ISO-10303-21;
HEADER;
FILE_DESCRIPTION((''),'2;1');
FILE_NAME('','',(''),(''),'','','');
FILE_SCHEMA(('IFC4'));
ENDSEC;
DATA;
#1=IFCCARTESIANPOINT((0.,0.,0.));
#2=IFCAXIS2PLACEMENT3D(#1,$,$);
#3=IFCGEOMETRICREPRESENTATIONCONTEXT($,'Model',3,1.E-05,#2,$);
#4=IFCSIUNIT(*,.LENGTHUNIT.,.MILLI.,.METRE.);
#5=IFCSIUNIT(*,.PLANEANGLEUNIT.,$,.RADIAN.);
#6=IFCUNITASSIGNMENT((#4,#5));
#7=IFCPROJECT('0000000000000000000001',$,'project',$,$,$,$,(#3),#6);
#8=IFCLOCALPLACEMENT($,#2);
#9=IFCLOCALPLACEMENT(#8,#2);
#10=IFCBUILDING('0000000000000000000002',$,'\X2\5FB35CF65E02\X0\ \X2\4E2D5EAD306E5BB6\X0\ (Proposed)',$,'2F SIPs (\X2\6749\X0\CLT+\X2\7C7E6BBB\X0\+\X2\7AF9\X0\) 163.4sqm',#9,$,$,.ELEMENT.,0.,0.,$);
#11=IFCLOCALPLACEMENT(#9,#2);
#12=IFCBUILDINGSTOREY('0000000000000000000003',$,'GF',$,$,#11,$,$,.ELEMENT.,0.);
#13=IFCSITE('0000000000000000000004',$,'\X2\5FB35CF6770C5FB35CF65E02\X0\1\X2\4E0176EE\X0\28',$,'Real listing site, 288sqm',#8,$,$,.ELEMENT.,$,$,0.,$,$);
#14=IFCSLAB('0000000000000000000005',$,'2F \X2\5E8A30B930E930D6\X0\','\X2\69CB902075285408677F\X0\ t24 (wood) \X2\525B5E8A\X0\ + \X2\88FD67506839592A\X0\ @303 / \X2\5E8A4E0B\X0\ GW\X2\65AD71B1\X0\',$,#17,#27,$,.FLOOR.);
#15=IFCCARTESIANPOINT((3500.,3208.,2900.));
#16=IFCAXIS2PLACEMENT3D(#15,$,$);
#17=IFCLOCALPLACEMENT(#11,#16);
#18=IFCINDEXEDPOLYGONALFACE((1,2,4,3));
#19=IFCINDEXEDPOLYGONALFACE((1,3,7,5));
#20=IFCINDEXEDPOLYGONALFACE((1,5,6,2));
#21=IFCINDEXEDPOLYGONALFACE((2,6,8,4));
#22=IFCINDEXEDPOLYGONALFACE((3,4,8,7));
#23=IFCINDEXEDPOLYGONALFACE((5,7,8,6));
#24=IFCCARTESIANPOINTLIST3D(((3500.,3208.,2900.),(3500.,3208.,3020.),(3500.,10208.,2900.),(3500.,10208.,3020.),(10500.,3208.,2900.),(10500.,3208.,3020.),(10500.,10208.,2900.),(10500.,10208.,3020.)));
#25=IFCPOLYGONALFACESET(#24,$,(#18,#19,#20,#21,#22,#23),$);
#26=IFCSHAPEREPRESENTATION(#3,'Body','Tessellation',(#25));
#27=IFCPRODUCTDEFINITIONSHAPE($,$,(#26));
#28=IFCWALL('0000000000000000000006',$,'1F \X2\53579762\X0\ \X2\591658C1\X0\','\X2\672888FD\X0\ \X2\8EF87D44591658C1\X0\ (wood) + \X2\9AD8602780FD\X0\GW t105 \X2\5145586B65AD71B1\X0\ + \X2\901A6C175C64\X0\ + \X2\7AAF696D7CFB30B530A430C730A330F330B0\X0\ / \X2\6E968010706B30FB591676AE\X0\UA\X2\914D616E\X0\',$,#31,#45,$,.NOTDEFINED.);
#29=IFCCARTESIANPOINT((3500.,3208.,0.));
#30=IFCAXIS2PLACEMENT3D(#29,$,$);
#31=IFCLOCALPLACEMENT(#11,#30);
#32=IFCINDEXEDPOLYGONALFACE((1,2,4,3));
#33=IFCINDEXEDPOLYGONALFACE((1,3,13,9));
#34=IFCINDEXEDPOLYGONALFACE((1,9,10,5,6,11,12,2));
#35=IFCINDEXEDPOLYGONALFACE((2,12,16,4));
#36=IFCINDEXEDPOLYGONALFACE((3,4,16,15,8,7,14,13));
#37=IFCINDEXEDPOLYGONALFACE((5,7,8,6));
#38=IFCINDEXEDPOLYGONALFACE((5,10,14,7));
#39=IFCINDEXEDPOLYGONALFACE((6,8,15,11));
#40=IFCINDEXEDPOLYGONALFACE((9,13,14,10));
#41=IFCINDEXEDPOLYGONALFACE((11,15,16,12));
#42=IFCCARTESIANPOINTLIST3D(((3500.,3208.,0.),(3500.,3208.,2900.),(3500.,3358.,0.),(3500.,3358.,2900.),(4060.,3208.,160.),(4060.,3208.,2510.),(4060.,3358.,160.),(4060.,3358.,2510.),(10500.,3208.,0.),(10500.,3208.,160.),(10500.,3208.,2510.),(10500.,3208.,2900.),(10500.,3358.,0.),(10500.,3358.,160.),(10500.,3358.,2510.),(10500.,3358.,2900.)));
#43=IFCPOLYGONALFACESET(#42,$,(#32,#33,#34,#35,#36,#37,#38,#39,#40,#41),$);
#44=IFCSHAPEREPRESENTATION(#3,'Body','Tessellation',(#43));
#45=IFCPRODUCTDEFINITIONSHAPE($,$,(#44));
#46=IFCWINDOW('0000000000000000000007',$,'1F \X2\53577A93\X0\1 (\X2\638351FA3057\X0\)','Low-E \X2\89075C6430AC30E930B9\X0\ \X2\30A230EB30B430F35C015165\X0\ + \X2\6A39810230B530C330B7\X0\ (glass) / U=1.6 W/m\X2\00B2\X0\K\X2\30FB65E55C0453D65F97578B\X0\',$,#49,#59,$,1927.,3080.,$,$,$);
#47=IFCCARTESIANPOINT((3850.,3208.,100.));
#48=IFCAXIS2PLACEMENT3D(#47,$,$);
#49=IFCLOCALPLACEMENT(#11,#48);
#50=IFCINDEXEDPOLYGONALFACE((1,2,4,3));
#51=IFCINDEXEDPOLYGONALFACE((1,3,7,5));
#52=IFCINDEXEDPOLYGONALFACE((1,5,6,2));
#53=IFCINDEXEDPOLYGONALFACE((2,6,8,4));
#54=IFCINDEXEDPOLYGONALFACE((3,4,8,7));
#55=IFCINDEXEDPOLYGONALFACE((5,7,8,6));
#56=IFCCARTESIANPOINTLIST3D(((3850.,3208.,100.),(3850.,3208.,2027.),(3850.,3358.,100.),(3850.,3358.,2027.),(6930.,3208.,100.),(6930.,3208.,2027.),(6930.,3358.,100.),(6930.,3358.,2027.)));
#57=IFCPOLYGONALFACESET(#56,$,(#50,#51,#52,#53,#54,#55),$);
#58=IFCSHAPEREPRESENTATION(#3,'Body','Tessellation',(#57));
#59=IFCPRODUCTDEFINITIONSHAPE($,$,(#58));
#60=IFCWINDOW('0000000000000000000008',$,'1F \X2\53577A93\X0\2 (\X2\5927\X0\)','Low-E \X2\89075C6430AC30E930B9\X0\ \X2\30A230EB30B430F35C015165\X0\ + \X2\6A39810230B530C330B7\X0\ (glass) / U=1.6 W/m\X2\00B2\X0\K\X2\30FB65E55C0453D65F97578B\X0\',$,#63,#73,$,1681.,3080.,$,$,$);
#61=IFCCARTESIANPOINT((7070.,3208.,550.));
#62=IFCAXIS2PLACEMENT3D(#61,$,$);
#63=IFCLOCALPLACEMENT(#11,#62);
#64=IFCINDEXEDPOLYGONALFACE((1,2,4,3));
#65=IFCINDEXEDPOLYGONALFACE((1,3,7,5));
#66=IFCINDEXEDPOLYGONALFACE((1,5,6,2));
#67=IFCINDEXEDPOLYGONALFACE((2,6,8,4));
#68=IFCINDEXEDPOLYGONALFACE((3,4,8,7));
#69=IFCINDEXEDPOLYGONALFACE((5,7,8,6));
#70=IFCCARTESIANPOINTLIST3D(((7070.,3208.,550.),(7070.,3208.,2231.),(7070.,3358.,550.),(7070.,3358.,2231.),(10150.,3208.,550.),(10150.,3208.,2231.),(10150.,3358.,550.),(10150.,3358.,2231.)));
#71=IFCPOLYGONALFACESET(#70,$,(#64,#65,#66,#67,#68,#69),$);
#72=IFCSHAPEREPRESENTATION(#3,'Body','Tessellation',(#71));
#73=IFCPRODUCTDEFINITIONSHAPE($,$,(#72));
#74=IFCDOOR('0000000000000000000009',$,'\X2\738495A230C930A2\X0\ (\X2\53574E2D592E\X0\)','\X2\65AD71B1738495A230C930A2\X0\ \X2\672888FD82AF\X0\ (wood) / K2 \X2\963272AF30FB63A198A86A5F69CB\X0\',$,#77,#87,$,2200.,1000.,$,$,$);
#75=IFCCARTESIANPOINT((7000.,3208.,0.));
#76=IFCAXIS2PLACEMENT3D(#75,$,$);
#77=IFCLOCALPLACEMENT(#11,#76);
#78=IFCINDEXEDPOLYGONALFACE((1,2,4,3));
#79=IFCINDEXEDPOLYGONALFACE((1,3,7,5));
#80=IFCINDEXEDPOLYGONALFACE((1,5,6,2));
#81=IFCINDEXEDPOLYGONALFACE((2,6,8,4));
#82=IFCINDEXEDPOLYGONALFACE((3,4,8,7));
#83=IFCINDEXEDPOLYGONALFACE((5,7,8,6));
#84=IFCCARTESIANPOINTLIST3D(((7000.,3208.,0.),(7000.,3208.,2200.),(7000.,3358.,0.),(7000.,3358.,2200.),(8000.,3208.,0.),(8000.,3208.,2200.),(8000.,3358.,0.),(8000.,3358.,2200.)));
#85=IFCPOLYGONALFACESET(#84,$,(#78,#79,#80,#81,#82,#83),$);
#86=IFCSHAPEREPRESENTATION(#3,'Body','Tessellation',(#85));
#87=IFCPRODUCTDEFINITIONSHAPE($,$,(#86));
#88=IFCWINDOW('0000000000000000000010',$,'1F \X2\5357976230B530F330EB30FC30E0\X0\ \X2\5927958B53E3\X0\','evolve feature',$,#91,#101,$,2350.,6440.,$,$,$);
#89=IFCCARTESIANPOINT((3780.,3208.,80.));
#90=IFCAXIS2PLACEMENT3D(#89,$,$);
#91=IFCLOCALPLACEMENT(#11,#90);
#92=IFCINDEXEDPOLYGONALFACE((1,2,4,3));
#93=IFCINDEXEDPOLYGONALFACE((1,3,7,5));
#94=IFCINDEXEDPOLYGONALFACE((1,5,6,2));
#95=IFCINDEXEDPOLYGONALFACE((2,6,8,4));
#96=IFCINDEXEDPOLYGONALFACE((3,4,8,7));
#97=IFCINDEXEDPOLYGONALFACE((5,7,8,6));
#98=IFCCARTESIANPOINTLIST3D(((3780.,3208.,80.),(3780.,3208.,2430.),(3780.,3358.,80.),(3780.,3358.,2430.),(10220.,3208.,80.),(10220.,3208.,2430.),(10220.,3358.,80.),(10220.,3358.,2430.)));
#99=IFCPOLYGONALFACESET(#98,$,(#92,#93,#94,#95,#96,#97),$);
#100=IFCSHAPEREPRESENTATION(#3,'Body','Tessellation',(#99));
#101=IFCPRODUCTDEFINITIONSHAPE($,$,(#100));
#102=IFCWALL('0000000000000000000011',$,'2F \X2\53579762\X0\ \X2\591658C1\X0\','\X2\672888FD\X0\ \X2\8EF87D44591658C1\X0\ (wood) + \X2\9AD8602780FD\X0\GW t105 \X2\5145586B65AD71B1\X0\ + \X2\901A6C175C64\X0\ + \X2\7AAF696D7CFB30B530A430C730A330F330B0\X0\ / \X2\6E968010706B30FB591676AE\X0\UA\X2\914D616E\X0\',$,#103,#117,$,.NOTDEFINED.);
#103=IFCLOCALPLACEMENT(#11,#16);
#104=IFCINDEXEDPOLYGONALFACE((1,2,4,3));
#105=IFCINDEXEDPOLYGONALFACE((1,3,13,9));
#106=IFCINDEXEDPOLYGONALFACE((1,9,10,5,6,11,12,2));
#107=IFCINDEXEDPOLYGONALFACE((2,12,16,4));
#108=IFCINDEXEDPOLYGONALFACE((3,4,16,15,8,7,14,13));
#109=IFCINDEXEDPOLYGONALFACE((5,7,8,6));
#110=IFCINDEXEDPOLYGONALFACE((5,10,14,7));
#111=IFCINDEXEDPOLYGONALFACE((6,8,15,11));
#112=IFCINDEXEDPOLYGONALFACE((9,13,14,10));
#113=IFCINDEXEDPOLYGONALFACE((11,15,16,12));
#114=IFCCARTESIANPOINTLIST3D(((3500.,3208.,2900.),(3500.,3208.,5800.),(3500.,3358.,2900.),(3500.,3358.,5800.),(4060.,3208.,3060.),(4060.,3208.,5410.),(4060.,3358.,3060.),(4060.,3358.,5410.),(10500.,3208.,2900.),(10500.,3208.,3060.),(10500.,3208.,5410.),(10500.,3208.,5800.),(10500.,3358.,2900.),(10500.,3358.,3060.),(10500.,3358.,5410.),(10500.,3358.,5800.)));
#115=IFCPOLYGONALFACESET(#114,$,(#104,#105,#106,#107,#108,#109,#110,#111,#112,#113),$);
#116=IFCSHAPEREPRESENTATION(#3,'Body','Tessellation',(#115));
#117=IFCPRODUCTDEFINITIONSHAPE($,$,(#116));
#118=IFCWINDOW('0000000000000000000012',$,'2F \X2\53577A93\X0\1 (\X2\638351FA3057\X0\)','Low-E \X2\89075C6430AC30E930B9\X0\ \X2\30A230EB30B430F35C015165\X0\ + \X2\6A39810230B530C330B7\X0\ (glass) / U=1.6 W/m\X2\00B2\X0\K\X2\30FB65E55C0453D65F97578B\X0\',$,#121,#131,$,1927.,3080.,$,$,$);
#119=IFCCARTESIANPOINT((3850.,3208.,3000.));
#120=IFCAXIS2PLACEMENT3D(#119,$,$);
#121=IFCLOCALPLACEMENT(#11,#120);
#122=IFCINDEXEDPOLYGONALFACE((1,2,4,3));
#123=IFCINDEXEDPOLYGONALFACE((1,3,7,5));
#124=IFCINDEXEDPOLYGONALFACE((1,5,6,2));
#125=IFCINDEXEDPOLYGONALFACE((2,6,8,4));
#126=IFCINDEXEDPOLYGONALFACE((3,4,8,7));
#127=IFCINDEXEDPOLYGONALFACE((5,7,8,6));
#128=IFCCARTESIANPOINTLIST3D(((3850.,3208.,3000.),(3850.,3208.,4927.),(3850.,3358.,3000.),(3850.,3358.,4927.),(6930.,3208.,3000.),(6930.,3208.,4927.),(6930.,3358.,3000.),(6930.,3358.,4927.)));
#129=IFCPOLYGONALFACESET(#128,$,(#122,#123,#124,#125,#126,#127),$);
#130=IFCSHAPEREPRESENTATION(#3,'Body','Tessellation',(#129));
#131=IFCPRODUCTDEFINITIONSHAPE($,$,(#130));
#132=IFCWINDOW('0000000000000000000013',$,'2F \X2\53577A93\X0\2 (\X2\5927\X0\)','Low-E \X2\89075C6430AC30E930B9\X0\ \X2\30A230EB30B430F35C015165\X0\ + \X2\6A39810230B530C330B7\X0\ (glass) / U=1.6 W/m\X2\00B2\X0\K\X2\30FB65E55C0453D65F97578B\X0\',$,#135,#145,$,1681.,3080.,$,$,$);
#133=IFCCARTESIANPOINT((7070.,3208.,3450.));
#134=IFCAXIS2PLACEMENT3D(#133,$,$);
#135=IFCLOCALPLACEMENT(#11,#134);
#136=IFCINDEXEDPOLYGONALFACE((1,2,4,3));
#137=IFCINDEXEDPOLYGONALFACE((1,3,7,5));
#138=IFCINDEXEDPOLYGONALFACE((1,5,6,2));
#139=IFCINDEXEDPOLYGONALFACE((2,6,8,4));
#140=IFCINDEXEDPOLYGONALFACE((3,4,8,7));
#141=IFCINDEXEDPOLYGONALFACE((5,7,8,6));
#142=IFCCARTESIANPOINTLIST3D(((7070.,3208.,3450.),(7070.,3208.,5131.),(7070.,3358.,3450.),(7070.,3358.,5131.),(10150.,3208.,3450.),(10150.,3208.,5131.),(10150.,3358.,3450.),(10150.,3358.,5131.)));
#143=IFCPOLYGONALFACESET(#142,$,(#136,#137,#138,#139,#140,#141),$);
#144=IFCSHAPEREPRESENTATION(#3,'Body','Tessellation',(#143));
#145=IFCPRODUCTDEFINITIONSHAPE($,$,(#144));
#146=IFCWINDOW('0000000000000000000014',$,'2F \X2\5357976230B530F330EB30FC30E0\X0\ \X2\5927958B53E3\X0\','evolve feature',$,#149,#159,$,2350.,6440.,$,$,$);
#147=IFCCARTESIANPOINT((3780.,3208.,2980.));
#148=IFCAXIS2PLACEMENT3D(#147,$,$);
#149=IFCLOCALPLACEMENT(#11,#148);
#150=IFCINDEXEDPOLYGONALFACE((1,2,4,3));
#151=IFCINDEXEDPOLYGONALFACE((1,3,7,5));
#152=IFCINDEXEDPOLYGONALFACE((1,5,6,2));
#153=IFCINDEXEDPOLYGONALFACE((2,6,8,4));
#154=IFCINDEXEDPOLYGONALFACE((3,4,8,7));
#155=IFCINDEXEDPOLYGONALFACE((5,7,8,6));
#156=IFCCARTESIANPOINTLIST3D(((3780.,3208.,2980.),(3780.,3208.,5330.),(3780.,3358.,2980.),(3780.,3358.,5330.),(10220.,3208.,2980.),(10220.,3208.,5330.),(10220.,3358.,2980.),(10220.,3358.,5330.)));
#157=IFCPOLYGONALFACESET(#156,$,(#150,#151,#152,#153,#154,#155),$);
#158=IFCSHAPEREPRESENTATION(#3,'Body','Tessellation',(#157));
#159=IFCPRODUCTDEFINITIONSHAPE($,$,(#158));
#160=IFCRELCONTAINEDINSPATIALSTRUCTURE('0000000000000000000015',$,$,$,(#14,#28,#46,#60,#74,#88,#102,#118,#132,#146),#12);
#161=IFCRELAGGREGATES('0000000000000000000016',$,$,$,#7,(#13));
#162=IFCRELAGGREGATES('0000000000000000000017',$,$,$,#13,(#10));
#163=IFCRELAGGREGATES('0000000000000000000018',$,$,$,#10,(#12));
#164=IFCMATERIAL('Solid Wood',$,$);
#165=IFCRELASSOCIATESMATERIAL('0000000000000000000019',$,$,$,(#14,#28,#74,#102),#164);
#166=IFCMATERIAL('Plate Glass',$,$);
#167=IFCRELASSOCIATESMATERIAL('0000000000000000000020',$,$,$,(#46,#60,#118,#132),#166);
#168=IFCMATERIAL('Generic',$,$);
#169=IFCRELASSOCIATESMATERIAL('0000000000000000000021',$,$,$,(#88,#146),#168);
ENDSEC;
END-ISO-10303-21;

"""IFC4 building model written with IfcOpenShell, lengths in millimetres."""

from ifc_helpers import new_model, si_unit, frame, frame_2d, origin, place, context, project, spatial, rectangle, extrude, material, element, fill, save


model = new_model("IFC4")

# Units and contexts
model_context = context("Model", 3, precision=1e-05, world=origin())
ifc_project = project(units=[si_unit("LENGTHUNIT", "METRE", prefix="MILLI"), si_unit("PLANEANGLEUNIT", "RADIAN")], contexts=[model_context])

# Site, building, storey
site_placement = place(None, origin())
site = spatial("IfcSite", under=ifc_project, at=site_placement, Name="徳島県徳島市1丁目28", ObjectType="Real listing site, 288sqm", CompositionType="ELEMENT", RefElevation=0.0)
building_placement = place(site_placement, origin())
building = spatial("IfcBuilding", under=site, at=building_placement, Name="徳島市 中庭の家 (Proposed)", ObjectType="2F SIPs (杉CLT+籾殻+竹) 163.4sqm", CompositionType="ELEMENT", ElevationOfRefHeight=0.0, ElevationOfTerrain=0.0)
storey_placement = place(building_placement, origin())
storey = spatial("IfcBuildingStorey", under=building, at=storey_placement, Name="GF", CompositionType="ELEMENT", Elevation=0.0)

# Slab
ifc_material_1 = material(Name="Solid Wood")
slab_1_placement = place(storey_placement, frame((3500.0, 3208.0, 2900.0)))
element("IfcSlab", 1, at=slab_1_placement, inside=storey, material=ifc_material_1, Name="2F 床スラブ", Description="構造用合板 t24 (wood) 剛床 + 製材根太 @303 / 床下 GW断熱", PredefinedType="FLOOR", context=model_context, shape_type="SweptSolid", body=[
    extrude(rectangle(XDim=7000.0, YDim=7000.0, at=frame_2d((3500.0, 3500.0))), frame((3500.0, 3208.0, 2900.0)), (0.0, 0.0, 1.0), 120.0),
])
ifc_material_2 = material(Name="Generic")

# Wall, openings, windows, door
wall_1_placement = place(storey_placement, frame((3500.0, 3208.0, 0.0)))
wall_1 = element("IfcWall", 2, at=wall_1_placement, inside=storey, material=ifc_material_1, Name="1F 南面 外壁", Description="木製 軸組外壁 (wood) + 高性能GW t105 充填断熱 + 通気層 + 窯業系サイディング / 準耐火・外皮UA配慮", PredefinedType="NOTDEFINED", context=model_context, shape_type="SweptSolid", body=[
    extrude(rectangle(XDim=7000.0, YDim=150.0, at=frame_2d((3500.0, 75.0))), frame((3500.0, 3208.0, 0.0)), (0.0, 0.0, 1.0), 2900.0),
])
opening_1_placement = place(storey_placement, frame((3850.0, 3208.0, 100.0)))
opening_1 = element("IfcOpeningElement", 3, at=opening_1_placement, cuts=wall_1, PredefinedType="NOTDEFINED", context=model_context, shape_type="SweptSolid", body=[
    extrude(rectangle(XDim=3080.0, YDim=150.0, at=frame_2d((1540.0, 75.0))), frame((3850.0, 3208.0, 100.0)), (0.0, 0.0, 1.0), 1927.0),
])
opening_2_placement = place(storey_placement, frame((7070.0, 3208.0, 550.0)))
opening_2 = element("IfcOpeningElement", 4, at=opening_2_placement, cuts=wall_1, PredefinedType="NOTDEFINED", context=model_context, shape_type="SweptSolid", body=[
    extrude(rectangle(XDim=3080.0, YDim=150.0, at=frame_2d((1540.0, 75.0))), frame((7070.0, 3208.0, 550.0)), (0.0, 0.0, 1.0), 1681.0),
])
opening_3_placement = place(storey_placement, frame((7000.0, 3208.0, 0.0)))
opening_3 = element("IfcOpeningElement", 5, at=opening_3_placement, cuts=wall_1, PredefinedType="NOTDEFINED", context=model_context, shape_type="SweptSolid", body=[
    extrude(rectangle(XDim=1000.0, YDim=150.0, at=frame_2d((500.0, 75.0))), frame((7000.0, 3208.0, 0.0)), (0.0, 0.0, 1.0), 2200.0),
])
opening_4_placement = place(storey_placement, frame((3780.0, 3208.0, 80.0)))
opening_4 = element("IfcOpeningElement", 6, at=opening_4_placement, cuts=wall_1, PredefinedType="NOTDEFINED", context=model_context, shape_type="SweptSolid", body=[
    extrude(rectangle(XDim=6440.0, YDim=150.0, at=frame_2d((3220.0, 75.0))), frame((3780.0, 3208.0, 80.0)), (0.0, 0.0, 1.0), 2350.0),
])
ifc_material_3 = material(Name="Plate Glass")
window_1_placement = place(storey_placement, frame((3850.0, 3208.0, 100.0)))
window_1 = element("IfcWindow", 7, at=window_1_placement, inside=storey, material=ifc_material_3, Name="1F 南窓1 (掃出し)", Description="Low-E 複層ガラス アルゴン封入 + 樹脂サッシ (glass) / U=1.6 W/m²K・日射取得型", OverallHeight=1927.0, OverallWidth=3080.0, context=model_context, shape_type="SweptSolid", body=[
    extrude(rectangle(XDim=3080.0, YDim=150.0, at=frame_2d((1540.0, 75.0))), frame((3850.0, 3208.0, 100.0)), (0.0, 0.0, 1.0), 1927.0),
])
fill(opening_1, window_1)
window_2_placement = place(storey_placement, frame((7070.0, 3208.0, 550.0)))
window_2 = element("IfcWindow", 8, at=window_2_placement, inside=storey, material=ifc_material_3, Name="1F 南窓2 (大)", Description="Low-E 複層ガラス アルゴン封入 + 樹脂サッシ (glass) / U=1.6 W/m²K・日射取得型", OverallHeight=1681.0, OverallWidth=3080.0, context=model_context, shape_type="SweptSolid", body=[
    extrude(rectangle(XDim=3080.0, YDim=150.0, at=frame_2d((1540.0, 75.0))), frame((7070.0, 3208.0, 550.0)), (0.0, 0.0, 1.0), 1681.0),
])
fill(opening_2, window_2)
door_placement = place(storey_placement, frame((7000.0, 3208.0, 0.0)))
door = element("IfcDoor", 9, at=door_placement, inside=storey, material=ifc_material_1, Name="玄関ドア (南中央)", Description="断熱玄関ドア 木製芯 (wood) / K2 防犯・採風機構", OverallHeight=2200.0, OverallWidth=1000.0, context=model_context, shape_type="SweptSolid", body=[
    extrude(rectangle(XDim=1000.0, YDim=150.0, at=frame_2d((500.0, 75.0))), frame((7000.0, 3208.0, 0.0)), (0.0, 0.0, 1.0), 2200.0),
])
fill(opening_3, door)
window_3_placement = place(storey_placement, frame((3780.0, 3208.0, 80.0)))
window_3 = element("IfcWindow", 10, at=window_3_placement, inside=storey, material=ifc_material_2, Name="1F 南面サンルーム 大開口", Description="evolve feature", OverallHeight=2350.0, OverallWidth=6440.0, context=model_context, shape_type="SweptSolid", body=[
    extrude(rectangle(XDim=6440.0, YDim=150.0, at=frame_2d((3220.0, 75.0))), frame((3780.0, 3208.0, 80.0)), (0.0, 0.0, 1.0), 2350.0),
])
fill(opening_4, window_3)

# Wall, openings, windows
wall_2_placement = place(storey_placement, frame((3500.0, 3208.0, 2900.0)))
wall_2 = element("IfcWall", 11, at=wall_2_placement, inside=storey, material=ifc_material_1, Name="2F 南面 外壁", Description="木製 軸組外壁 (wood) + 高性能GW t105 充填断熱 + 通気層 + 窯業系サイディング / 準耐火・外皮UA配慮", PredefinedType="NOTDEFINED", context=model_context, shape_type="SweptSolid", body=[
    extrude(rectangle(XDim=7000.0, YDim=150.0, at=frame_2d((3500.0, 75.0))), frame((3500.0, 3208.0, 2900.0)), (0.0, 0.0, 1.0), 2900.0),
])
opening_5_placement = place(storey_placement, frame((3850.0, 3208.0, 3000.0)))
opening_5 = element("IfcOpeningElement", 12, at=opening_5_placement, cuts=wall_2, PredefinedType="NOTDEFINED", context=model_context, shape_type="SweptSolid", body=[
    extrude(rectangle(XDim=3080.0, YDim=150.0, at=frame_2d((1540.0, 75.0))), frame((3850.0, 3208.0, 3000.0)), (0.0, 0.0, 1.0), 1927.0),
])
opening_6_placement = place(storey_placement, frame((7070.0, 3208.0, 3450.0)))
opening_6 = element("IfcOpeningElement", 13, at=opening_6_placement, cuts=wall_2, PredefinedType="NOTDEFINED", context=model_context, shape_type="SweptSolid", body=[
    extrude(rectangle(XDim=3080.0, YDim=150.0, at=frame_2d((1540.0, 75.0))), frame((7070.0, 3208.0, 3450.0)), (0.0, 0.0, 1.0), 1681.0),
])
opening_7_placement = place(storey_placement, frame((3780.0, 3208.0, 2980.0)))
opening_7 = element("IfcOpeningElement", 14, at=opening_7_placement, cuts=wall_2, PredefinedType="NOTDEFINED", context=model_context, shape_type="SweptSolid", body=[
    extrude(rectangle(XDim=6440.0, YDim=150.0, at=frame_2d((3220.0, 75.0))), frame((3780.0, 3208.0, 2980.0)), (0.0, 0.0, 1.0), 2350.0),
])
window_4_placement = place(storey_placement, frame((3850.0, 3208.0, 3000.0)))
window_4 = element("IfcWindow", 15, at=window_4_placement, inside=storey, material=ifc_material_3, Name="2F 南窓1 (掃出し)", Description="Low-E 複層ガラス アルゴン封入 + 樹脂サッシ (glass) / U=1.6 W/m²K・日射取得型", OverallHeight=1927.0, OverallWidth=3080.0, context=model_context, shape_type="SweptSolid", body=[
    extrude(rectangle(XDim=3080.0, YDim=150.0, at=frame_2d((1540.0, 75.0))), frame((3850.0, 3208.0, 3000.0)), (0.0, 0.0, 1.0), 1927.0),
])
fill(opening_5, window_4)
window_5_placement = place(storey_placement, frame((7070.0, 3208.0, 3450.0)))
window_5 = element("IfcWindow", 16, at=window_5_placement, inside=storey, material=ifc_material_3, Name="2F 南窓2 (大)", Description="Low-E 複層ガラス アルゴン封入 + 樹脂サッシ (glass) / U=1.6 W/m²K・日射取得型", OverallHeight=1681.0, OverallWidth=3080.0, context=model_context, shape_type="SweptSolid", body=[
    extrude(rectangle(XDim=3080.0, YDim=150.0, at=frame_2d((1540.0, 75.0))), frame((7070.0, 3208.0, 3450.0)), (0.0, 0.0, 1.0), 1681.0),
])
fill(opening_6, window_5)
window_6_placement = place(storey_placement, frame((3780.0, 3208.0, 2980.0)))
window_6 = element("IfcWindow", 17, at=window_6_placement, inside=storey, material=ifc_material_2, Name="2F 南面サンルーム 大開口", Description="evolve feature", OverallHeight=2350.0, OverallWidth=6440.0, context=model_context, shape_type="SweptSolid", body=[
    extrude(rectangle(XDim=6440.0, YDim=150.0, at=frame_2d((3220.0, 75.0))), frame((3780.0, 3208.0, 2980.0)), (0.0, 0.0, 1.0), 2350.0),
])
fill(opening_7, window_6)

save(model, "model.ifc")
